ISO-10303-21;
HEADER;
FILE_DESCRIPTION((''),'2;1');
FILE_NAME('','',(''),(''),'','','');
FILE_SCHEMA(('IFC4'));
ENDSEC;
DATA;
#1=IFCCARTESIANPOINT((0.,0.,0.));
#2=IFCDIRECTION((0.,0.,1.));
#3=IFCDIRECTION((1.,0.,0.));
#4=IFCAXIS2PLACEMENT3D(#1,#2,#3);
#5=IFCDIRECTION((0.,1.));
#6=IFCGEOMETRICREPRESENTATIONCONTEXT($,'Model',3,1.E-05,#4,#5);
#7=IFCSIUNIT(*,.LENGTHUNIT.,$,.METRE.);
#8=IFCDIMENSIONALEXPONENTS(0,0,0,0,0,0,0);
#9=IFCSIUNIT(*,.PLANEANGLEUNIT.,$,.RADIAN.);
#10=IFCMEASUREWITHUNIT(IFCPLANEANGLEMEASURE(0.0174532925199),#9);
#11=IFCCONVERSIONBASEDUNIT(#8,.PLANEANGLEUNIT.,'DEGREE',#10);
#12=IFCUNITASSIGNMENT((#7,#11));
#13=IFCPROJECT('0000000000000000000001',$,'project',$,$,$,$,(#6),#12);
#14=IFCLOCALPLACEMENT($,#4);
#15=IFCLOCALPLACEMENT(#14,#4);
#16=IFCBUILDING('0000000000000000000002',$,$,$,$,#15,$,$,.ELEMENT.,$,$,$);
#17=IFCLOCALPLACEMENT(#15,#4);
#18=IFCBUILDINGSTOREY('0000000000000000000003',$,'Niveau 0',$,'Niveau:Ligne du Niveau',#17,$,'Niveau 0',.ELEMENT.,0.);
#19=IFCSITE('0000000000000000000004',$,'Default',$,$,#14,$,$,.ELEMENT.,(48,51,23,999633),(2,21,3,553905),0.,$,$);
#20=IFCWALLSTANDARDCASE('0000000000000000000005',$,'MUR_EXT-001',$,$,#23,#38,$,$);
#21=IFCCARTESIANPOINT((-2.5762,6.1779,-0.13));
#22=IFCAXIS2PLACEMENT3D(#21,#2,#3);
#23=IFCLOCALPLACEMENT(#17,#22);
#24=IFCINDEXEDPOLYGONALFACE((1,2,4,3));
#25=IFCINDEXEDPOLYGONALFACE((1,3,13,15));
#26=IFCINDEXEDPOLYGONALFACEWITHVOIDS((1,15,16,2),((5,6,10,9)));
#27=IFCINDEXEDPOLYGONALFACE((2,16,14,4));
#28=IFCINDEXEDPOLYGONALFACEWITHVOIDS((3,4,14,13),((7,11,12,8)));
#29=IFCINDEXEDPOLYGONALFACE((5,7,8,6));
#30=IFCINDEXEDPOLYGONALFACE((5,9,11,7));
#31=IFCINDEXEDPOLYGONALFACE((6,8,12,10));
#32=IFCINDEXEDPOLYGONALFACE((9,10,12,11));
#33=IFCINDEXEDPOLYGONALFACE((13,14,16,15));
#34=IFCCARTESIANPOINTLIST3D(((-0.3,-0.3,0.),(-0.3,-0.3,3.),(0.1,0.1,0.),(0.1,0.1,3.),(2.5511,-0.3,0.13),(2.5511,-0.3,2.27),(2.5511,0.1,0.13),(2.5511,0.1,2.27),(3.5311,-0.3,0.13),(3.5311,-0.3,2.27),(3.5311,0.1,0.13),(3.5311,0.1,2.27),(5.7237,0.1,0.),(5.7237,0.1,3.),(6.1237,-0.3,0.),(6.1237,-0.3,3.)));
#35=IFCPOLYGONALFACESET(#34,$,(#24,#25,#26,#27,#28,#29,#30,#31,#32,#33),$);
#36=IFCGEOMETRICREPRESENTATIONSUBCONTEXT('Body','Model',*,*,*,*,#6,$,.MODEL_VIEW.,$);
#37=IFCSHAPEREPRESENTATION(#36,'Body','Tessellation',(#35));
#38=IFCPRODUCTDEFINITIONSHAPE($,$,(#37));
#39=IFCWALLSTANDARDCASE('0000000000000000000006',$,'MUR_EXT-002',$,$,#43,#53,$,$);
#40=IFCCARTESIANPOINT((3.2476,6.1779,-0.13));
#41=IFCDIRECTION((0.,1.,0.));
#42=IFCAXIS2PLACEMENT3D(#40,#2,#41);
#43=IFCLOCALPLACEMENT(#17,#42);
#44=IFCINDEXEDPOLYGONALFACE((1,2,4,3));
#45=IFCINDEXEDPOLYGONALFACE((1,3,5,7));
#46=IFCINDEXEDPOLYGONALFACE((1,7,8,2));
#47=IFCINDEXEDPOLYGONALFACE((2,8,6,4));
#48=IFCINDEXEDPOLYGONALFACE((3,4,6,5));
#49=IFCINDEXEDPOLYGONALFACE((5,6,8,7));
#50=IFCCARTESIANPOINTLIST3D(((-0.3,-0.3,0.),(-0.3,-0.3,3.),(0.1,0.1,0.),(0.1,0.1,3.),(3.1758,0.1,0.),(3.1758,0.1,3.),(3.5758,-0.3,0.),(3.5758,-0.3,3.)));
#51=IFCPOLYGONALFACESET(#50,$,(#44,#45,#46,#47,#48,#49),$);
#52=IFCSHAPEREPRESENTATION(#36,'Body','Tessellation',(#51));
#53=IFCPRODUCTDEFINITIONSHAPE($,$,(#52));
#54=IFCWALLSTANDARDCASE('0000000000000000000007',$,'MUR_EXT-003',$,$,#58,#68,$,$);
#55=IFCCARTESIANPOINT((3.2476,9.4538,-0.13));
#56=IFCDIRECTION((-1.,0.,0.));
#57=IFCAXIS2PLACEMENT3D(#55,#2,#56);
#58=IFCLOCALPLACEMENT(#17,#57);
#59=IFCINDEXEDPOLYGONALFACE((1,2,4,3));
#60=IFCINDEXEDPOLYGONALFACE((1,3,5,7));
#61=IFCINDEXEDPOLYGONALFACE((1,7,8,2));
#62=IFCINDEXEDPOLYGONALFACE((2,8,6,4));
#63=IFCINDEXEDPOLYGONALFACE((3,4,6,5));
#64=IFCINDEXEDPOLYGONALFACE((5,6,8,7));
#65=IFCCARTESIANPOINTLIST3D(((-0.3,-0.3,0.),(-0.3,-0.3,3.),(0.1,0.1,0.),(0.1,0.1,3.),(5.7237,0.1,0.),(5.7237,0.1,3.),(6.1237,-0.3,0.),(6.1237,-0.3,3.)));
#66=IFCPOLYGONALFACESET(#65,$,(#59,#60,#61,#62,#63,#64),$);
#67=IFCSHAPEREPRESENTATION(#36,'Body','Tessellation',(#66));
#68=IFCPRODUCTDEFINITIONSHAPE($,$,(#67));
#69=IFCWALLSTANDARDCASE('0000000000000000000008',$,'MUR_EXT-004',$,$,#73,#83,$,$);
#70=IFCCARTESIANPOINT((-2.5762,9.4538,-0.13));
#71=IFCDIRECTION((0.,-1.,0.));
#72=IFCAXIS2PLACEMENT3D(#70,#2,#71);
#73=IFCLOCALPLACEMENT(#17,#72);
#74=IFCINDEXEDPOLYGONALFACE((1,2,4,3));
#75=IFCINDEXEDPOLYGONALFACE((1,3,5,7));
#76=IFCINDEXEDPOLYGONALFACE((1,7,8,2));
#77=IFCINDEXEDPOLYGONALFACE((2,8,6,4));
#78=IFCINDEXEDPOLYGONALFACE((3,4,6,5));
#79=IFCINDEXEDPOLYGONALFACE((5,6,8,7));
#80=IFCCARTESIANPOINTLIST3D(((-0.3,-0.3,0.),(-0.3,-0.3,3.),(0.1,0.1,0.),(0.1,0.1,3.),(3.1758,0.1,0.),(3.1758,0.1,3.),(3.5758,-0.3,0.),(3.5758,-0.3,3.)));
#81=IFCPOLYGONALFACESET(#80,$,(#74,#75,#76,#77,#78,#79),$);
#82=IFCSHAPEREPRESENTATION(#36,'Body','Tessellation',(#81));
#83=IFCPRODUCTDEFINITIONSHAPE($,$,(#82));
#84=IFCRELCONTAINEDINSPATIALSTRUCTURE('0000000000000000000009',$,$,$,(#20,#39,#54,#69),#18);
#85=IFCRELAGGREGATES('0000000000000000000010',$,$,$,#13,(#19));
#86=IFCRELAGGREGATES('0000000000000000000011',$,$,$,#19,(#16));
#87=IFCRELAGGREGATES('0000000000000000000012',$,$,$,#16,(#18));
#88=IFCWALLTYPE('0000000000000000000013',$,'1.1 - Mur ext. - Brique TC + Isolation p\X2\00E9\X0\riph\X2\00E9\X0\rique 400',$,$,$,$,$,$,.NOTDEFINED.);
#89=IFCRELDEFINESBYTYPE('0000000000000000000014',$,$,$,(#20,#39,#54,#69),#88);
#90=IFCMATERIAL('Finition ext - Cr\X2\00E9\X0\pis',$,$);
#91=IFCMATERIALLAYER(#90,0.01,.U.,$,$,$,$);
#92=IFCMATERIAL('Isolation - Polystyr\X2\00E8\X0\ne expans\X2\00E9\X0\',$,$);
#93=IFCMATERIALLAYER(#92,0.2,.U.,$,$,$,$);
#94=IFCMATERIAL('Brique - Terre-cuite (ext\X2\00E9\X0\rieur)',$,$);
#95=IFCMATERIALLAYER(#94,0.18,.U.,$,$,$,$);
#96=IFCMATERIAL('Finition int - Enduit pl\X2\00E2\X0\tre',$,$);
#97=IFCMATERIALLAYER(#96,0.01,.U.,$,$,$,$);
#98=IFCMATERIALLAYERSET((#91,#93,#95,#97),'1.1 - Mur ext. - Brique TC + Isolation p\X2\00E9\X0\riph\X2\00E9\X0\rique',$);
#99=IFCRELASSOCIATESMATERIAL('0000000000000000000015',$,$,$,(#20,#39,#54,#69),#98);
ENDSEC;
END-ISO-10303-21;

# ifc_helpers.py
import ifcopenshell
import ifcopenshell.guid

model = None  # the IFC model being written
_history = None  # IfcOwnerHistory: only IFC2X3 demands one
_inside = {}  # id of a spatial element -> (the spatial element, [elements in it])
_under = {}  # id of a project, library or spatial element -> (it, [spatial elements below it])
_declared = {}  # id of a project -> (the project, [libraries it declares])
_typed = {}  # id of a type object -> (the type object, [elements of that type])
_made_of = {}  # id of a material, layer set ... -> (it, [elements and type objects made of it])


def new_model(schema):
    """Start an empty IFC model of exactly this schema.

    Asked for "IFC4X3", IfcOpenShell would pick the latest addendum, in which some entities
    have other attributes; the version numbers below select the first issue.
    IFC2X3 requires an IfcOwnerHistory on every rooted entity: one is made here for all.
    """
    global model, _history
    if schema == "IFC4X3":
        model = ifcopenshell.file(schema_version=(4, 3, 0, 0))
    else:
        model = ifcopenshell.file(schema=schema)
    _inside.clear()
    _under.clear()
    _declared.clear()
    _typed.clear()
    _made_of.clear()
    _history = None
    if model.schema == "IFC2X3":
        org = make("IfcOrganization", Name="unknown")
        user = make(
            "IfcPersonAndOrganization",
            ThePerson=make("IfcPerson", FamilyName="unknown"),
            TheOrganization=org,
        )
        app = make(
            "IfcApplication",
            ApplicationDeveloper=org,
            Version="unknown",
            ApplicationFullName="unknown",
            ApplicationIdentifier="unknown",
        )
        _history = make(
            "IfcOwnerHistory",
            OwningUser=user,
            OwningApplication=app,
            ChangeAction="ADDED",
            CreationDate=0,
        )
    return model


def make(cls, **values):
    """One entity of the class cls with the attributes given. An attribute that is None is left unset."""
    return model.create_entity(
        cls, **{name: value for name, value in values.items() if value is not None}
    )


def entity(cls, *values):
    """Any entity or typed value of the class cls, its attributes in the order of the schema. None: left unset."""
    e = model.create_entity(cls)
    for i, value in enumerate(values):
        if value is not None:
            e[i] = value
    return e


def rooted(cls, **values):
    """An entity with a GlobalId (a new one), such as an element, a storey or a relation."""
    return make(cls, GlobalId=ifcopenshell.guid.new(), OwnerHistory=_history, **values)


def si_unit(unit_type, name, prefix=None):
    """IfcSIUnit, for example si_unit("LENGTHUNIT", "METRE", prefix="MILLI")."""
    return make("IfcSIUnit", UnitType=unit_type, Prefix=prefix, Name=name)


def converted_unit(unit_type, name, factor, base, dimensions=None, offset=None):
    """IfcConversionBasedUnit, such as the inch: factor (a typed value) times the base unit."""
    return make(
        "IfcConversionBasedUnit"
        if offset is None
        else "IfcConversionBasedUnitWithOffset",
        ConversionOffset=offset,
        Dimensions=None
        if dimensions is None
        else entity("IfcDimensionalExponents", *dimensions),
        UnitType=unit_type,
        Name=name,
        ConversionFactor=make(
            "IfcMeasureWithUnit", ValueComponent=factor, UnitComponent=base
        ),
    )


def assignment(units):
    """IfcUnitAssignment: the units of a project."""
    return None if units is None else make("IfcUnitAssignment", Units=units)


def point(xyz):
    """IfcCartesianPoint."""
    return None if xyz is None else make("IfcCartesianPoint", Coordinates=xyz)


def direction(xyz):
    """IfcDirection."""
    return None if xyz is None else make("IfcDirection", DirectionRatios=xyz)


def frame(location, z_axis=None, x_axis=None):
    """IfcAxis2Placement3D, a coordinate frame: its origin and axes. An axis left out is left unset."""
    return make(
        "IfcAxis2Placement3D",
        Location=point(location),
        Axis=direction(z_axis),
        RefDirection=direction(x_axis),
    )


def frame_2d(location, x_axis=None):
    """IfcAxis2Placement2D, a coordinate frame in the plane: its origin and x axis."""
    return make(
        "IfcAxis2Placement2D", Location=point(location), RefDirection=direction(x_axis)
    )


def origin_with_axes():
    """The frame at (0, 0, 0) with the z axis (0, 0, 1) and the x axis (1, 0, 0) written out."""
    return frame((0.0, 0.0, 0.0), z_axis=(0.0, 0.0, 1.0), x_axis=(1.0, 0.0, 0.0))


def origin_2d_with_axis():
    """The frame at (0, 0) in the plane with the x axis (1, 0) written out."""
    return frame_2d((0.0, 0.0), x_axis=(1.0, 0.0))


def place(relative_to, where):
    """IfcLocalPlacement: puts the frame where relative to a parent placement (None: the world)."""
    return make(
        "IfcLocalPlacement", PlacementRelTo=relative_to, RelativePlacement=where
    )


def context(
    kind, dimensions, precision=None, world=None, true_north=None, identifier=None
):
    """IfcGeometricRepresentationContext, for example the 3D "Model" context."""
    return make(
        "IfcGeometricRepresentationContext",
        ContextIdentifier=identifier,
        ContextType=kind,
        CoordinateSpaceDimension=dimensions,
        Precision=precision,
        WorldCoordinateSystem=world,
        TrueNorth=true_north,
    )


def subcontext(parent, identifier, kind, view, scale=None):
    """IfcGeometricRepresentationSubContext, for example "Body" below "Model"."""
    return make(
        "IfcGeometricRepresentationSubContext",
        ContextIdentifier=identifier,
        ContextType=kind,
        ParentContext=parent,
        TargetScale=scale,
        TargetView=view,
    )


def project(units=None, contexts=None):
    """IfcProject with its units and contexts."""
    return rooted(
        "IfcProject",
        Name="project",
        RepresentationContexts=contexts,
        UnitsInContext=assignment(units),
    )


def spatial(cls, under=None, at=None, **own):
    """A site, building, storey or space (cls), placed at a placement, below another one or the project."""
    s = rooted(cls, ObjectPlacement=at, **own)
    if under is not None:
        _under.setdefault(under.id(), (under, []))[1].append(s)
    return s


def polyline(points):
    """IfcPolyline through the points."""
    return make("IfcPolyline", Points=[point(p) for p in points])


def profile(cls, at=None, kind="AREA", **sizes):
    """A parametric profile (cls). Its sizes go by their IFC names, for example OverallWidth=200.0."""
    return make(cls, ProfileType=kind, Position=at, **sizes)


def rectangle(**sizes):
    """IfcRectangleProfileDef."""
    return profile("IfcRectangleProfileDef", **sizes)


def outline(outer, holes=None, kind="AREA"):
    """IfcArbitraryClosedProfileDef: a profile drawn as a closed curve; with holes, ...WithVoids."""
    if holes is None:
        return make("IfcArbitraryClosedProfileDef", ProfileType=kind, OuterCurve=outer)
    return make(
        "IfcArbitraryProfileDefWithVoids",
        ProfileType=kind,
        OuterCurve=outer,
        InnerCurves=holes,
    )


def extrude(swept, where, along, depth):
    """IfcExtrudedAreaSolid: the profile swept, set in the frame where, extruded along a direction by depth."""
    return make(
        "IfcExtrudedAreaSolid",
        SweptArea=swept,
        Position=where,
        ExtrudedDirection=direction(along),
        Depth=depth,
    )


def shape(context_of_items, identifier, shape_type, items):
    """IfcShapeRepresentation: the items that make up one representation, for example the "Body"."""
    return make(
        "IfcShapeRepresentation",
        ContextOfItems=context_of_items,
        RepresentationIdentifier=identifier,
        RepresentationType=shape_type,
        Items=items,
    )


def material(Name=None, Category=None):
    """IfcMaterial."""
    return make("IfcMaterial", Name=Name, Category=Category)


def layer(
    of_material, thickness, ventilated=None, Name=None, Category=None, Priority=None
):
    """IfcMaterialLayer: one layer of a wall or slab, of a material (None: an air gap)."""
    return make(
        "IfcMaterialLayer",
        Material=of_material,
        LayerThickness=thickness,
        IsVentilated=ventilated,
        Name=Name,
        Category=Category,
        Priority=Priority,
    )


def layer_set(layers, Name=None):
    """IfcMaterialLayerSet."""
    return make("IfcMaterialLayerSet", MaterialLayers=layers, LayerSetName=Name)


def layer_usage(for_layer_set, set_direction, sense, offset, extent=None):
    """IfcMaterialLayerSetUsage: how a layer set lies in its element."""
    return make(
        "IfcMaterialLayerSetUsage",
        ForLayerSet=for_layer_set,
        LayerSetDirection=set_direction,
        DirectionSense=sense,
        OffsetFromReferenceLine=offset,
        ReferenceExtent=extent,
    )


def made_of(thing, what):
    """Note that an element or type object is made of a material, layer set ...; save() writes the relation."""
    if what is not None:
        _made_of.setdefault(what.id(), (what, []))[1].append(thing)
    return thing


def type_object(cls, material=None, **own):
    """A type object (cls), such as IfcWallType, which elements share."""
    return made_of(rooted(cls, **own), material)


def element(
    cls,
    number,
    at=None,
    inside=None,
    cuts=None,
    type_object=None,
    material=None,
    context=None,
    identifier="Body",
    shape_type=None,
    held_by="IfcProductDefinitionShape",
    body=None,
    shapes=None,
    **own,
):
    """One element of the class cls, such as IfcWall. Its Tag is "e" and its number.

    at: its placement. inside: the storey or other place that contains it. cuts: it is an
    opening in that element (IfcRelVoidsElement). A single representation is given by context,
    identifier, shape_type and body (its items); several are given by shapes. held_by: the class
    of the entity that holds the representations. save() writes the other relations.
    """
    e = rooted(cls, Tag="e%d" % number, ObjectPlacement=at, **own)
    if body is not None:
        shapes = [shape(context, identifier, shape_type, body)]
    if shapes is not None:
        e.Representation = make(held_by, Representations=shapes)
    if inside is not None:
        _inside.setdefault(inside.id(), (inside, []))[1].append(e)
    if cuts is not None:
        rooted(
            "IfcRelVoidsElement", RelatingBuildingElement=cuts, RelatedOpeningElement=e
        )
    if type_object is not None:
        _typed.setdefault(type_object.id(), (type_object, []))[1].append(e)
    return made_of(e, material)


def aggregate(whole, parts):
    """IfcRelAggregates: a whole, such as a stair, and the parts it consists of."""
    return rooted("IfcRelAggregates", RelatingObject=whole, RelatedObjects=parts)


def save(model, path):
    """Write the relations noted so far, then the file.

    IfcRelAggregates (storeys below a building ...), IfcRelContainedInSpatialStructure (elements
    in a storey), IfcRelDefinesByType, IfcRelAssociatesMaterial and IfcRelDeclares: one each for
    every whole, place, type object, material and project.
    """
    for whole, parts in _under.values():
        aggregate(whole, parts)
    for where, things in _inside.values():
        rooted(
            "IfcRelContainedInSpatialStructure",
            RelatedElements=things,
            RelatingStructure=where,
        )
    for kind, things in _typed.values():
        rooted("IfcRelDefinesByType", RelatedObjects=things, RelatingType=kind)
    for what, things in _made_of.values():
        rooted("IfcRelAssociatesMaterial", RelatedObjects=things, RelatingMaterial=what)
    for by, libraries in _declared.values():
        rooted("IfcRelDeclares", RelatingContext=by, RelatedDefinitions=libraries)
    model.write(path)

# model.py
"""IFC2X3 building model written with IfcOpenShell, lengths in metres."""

from ifc_helpers import new_model, entity, si_unit, converted_unit, direction, frame, origin_with_axes, origin_2d_with_axis, place, context, subcontext, project, spatial, polyline, rectangle, outline, extrude, material, layer, layer_set, layer_usage, type_object, element, save


model = new_model("IFC2X3")

# Units and contexts
model_context = context("Model", 3, precision=1e-05, world=origin_with_axes(), true_north=direction((0.0, 1.0)))
body_context = subcontext(model_context, "Body", "Model", "MODEL_VIEW")
ifc_project = project(units=[si_unit("LENGTHUNIT", "METRE"), converted_unit("PLANEANGLEUNIT", "DEGREE", entity("IfcPlaneAngleMeasure", 0.0174532925199), si_unit("PLANEANGLEUNIT", "RADIAN"), dimensions=[0, 0, 0, 0, 0, 0, 0])], contexts=[model_context])

# Site, building, storey
site_placement = place(None, origin_with_axes())
site = spatial("IfcSite", under=ifc_project, at=site_placement, Name="Default", CompositionType="ELEMENT", RefLatitude=(48, 51, 23, 999633), RefLongitude=(2, 21, 3, 553905), RefElevation=0.0)
building_placement = place(site_placement, origin_with_axes())
building = spatial("IfcBuilding", under=site, at=building_placement, CompositionType="ELEMENT")
storey_placement = place(building_placement, origin_with_axes())
storey = spatial("IfcBuildingStorey", under=building, at=storey_placement, Name="Niveau 0", ObjectType="Niveau:Ligne du Niveau", LongName="Niveau 0", CompositionType="ELEMENT", Elevation=0.0)

# Shared definitions
ifc_material_1 = material(Name="Finition int - Enduit plâtre")

# Wall, opening
ifc_material_2 = material(Name="Finition ext - Crépis")
ifc_layer_1 = layer(ifc_material_2, 0.01, ventilated="UNKNOWN")
ifc_material_3 = material(Name="Isolation - Polystyrène expansé")
ifc_layer_2 = layer(ifc_material_3, 0.2, ventilated="UNKNOWN")
ifc_material_4 = material(Name="Brique - Terre-cuite (extérieur)")
ifc_layer_3 = layer(ifc_material_4, 0.18, ventilated="UNKNOWN")
ifc_layer_4 = layer(ifc_material_1, 0.01, ventilated="UNKNOWN")
ifc_layer_set_1 = layer_set([ifc_layer_1, ifc_layer_2, ifc_layer_3, ifc_layer_4], Name="1.1 - Mur ext. - Brique TC + Isolation périphérique")
ifc_layer_usage_1 = layer_usage(ifc_layer_set_1, "AXIS2", "POSITIVE", -0.3)
wall_type_1 = type_object("IfcWallType", Name="1.1 - Mur ext. - Brique TC + Isolation périphérique 400", PredefinedType="NOTDEFINED")
wall_1_placement = place(storey_placement, frame((-2.5762, 6.1779, -0.13), z_axis=(0.0, 0.0, 1.0), x_axis=(1.0, 0.0, 0.0)))
wall_1 = element("IfcWallStandardCase", 1, at=wall_1_placement, inside=storey, type_object=wall_type_1, material=ifc_layer_usage_1, Name="MUR_EXT-001", context=body_context, shape_type="SweptSolid", body=[
    extrude(outline(polyline([(-0.3, -0.3), (6.1237, -0.3), (5.7237, 0.1), (0.1, 0.1), (-0.3, -0.3)])), origin_with_axes(), (0.0, 0.0, 1.0), 3.0),
])
opening_1_placement = place(wall_1_placement, frame((3.0411, 0.0, 0.13), z_axis=(0.0, 0.0, 1.0), x_axis=(1.0, 0.0, 0.0)))
element("IfcOpeningElement", 2, at=opening_1_placement, cuts=wall_1, context=body_context, shape_type="SweptSolid", body=[
    extrude(rectangle(XDim=0.98, YDim=2.14, at=origin_2d_with_axis()), frame((0.0, 0.4, 1.07), z_axis=(0.0, 1.0, 0.0), x_axis=(1.0, 0.0, 0.0)), (0.0, 0.0, -1.0), 1.2),
])

# Walls
ifc_layer_usage_2 = layer_usage(ifc_layer_set_1, "AXIS2", "POSITIVE", -0.3)
wall_2_placement = place(storey_placement, frame((3.2476, 6.1779, -0.13), z_axis=(0.0, 0.0, 1.0), x_axis=(0.0, 1.0, 0.0)))
element("IfcWallStandardCase", 3, at=wall_2_placement, inside=storey, type_object=wall_type_1, material=ifc_layer_usage_2, Name="MUR_EXT-002", context=body_context, shape_type="SweptSolid", body=[
    extrude(outline(polyline([(-0.3, -0.3), (3.5758, -0.3), (3.1758, 0.1), (0.1, 0.1), (-0.3, -0.3)])), origin_with_axes(), (0.0, 0.0, 1.0), 3.0),
])
ifc_layer_usage_3 = layer_usage(ifc_layer_set_1, "AXIS2", "POSITIVE", -0.3)
wall_3_placement = place(storey_placement, frame((3.2476, 9.4538, -0.13), z_axis=(0.0, 0.0, 1.0), x_axis=(-1.0, 0.0, 0.0)))
element("IfcWallStandardCase", 4, at=wall_3_placement, inside=storey, type_object=wall_type_1, material=ifc_layer_usage_3, Name="MUR_EXT-003", context=body_context, shape_type="SweptSolid", body=[
    extrude(outline(polyline([(-0.3, -0.3), (6.1237, -0.3), (5.7237, 0.1), (0.1, 0.1), (-0.3, -0.3)])), origin_with_axes(), (0.0, 0.0, 1.0), 3.0),
])
ifc_layer_usage_4 = layer_usage(ifc_layer_set_1, "AXIS2", "POSITIVE", -0.3)
wall_4_placement = place(storey_placement, frame((-2.5762, 9.4538, -0.13), z_axis=(0.0, 0.0, 1.0), x_axis=(0.0, -1.0, 0.0)))
element("IfcWallStandardCase", 5, at=wall_4_placement, inside=storey, type_object=wall_type_1, material=ifc_layer_usage_4, Name="MUR_EXT-004", context=body_context, shape_type="SweptSolid", body=[
    extrude(outline(polyline([(-0.3, -0.3), (3.5758, -0.3), (3.1758, 0.1), (0.1, 0.1), (-0.3, -0.3)])), origin_with_axes(), (0.0, 0.0, 1.0), 3.0),
])

save(model, "model.ifc")
